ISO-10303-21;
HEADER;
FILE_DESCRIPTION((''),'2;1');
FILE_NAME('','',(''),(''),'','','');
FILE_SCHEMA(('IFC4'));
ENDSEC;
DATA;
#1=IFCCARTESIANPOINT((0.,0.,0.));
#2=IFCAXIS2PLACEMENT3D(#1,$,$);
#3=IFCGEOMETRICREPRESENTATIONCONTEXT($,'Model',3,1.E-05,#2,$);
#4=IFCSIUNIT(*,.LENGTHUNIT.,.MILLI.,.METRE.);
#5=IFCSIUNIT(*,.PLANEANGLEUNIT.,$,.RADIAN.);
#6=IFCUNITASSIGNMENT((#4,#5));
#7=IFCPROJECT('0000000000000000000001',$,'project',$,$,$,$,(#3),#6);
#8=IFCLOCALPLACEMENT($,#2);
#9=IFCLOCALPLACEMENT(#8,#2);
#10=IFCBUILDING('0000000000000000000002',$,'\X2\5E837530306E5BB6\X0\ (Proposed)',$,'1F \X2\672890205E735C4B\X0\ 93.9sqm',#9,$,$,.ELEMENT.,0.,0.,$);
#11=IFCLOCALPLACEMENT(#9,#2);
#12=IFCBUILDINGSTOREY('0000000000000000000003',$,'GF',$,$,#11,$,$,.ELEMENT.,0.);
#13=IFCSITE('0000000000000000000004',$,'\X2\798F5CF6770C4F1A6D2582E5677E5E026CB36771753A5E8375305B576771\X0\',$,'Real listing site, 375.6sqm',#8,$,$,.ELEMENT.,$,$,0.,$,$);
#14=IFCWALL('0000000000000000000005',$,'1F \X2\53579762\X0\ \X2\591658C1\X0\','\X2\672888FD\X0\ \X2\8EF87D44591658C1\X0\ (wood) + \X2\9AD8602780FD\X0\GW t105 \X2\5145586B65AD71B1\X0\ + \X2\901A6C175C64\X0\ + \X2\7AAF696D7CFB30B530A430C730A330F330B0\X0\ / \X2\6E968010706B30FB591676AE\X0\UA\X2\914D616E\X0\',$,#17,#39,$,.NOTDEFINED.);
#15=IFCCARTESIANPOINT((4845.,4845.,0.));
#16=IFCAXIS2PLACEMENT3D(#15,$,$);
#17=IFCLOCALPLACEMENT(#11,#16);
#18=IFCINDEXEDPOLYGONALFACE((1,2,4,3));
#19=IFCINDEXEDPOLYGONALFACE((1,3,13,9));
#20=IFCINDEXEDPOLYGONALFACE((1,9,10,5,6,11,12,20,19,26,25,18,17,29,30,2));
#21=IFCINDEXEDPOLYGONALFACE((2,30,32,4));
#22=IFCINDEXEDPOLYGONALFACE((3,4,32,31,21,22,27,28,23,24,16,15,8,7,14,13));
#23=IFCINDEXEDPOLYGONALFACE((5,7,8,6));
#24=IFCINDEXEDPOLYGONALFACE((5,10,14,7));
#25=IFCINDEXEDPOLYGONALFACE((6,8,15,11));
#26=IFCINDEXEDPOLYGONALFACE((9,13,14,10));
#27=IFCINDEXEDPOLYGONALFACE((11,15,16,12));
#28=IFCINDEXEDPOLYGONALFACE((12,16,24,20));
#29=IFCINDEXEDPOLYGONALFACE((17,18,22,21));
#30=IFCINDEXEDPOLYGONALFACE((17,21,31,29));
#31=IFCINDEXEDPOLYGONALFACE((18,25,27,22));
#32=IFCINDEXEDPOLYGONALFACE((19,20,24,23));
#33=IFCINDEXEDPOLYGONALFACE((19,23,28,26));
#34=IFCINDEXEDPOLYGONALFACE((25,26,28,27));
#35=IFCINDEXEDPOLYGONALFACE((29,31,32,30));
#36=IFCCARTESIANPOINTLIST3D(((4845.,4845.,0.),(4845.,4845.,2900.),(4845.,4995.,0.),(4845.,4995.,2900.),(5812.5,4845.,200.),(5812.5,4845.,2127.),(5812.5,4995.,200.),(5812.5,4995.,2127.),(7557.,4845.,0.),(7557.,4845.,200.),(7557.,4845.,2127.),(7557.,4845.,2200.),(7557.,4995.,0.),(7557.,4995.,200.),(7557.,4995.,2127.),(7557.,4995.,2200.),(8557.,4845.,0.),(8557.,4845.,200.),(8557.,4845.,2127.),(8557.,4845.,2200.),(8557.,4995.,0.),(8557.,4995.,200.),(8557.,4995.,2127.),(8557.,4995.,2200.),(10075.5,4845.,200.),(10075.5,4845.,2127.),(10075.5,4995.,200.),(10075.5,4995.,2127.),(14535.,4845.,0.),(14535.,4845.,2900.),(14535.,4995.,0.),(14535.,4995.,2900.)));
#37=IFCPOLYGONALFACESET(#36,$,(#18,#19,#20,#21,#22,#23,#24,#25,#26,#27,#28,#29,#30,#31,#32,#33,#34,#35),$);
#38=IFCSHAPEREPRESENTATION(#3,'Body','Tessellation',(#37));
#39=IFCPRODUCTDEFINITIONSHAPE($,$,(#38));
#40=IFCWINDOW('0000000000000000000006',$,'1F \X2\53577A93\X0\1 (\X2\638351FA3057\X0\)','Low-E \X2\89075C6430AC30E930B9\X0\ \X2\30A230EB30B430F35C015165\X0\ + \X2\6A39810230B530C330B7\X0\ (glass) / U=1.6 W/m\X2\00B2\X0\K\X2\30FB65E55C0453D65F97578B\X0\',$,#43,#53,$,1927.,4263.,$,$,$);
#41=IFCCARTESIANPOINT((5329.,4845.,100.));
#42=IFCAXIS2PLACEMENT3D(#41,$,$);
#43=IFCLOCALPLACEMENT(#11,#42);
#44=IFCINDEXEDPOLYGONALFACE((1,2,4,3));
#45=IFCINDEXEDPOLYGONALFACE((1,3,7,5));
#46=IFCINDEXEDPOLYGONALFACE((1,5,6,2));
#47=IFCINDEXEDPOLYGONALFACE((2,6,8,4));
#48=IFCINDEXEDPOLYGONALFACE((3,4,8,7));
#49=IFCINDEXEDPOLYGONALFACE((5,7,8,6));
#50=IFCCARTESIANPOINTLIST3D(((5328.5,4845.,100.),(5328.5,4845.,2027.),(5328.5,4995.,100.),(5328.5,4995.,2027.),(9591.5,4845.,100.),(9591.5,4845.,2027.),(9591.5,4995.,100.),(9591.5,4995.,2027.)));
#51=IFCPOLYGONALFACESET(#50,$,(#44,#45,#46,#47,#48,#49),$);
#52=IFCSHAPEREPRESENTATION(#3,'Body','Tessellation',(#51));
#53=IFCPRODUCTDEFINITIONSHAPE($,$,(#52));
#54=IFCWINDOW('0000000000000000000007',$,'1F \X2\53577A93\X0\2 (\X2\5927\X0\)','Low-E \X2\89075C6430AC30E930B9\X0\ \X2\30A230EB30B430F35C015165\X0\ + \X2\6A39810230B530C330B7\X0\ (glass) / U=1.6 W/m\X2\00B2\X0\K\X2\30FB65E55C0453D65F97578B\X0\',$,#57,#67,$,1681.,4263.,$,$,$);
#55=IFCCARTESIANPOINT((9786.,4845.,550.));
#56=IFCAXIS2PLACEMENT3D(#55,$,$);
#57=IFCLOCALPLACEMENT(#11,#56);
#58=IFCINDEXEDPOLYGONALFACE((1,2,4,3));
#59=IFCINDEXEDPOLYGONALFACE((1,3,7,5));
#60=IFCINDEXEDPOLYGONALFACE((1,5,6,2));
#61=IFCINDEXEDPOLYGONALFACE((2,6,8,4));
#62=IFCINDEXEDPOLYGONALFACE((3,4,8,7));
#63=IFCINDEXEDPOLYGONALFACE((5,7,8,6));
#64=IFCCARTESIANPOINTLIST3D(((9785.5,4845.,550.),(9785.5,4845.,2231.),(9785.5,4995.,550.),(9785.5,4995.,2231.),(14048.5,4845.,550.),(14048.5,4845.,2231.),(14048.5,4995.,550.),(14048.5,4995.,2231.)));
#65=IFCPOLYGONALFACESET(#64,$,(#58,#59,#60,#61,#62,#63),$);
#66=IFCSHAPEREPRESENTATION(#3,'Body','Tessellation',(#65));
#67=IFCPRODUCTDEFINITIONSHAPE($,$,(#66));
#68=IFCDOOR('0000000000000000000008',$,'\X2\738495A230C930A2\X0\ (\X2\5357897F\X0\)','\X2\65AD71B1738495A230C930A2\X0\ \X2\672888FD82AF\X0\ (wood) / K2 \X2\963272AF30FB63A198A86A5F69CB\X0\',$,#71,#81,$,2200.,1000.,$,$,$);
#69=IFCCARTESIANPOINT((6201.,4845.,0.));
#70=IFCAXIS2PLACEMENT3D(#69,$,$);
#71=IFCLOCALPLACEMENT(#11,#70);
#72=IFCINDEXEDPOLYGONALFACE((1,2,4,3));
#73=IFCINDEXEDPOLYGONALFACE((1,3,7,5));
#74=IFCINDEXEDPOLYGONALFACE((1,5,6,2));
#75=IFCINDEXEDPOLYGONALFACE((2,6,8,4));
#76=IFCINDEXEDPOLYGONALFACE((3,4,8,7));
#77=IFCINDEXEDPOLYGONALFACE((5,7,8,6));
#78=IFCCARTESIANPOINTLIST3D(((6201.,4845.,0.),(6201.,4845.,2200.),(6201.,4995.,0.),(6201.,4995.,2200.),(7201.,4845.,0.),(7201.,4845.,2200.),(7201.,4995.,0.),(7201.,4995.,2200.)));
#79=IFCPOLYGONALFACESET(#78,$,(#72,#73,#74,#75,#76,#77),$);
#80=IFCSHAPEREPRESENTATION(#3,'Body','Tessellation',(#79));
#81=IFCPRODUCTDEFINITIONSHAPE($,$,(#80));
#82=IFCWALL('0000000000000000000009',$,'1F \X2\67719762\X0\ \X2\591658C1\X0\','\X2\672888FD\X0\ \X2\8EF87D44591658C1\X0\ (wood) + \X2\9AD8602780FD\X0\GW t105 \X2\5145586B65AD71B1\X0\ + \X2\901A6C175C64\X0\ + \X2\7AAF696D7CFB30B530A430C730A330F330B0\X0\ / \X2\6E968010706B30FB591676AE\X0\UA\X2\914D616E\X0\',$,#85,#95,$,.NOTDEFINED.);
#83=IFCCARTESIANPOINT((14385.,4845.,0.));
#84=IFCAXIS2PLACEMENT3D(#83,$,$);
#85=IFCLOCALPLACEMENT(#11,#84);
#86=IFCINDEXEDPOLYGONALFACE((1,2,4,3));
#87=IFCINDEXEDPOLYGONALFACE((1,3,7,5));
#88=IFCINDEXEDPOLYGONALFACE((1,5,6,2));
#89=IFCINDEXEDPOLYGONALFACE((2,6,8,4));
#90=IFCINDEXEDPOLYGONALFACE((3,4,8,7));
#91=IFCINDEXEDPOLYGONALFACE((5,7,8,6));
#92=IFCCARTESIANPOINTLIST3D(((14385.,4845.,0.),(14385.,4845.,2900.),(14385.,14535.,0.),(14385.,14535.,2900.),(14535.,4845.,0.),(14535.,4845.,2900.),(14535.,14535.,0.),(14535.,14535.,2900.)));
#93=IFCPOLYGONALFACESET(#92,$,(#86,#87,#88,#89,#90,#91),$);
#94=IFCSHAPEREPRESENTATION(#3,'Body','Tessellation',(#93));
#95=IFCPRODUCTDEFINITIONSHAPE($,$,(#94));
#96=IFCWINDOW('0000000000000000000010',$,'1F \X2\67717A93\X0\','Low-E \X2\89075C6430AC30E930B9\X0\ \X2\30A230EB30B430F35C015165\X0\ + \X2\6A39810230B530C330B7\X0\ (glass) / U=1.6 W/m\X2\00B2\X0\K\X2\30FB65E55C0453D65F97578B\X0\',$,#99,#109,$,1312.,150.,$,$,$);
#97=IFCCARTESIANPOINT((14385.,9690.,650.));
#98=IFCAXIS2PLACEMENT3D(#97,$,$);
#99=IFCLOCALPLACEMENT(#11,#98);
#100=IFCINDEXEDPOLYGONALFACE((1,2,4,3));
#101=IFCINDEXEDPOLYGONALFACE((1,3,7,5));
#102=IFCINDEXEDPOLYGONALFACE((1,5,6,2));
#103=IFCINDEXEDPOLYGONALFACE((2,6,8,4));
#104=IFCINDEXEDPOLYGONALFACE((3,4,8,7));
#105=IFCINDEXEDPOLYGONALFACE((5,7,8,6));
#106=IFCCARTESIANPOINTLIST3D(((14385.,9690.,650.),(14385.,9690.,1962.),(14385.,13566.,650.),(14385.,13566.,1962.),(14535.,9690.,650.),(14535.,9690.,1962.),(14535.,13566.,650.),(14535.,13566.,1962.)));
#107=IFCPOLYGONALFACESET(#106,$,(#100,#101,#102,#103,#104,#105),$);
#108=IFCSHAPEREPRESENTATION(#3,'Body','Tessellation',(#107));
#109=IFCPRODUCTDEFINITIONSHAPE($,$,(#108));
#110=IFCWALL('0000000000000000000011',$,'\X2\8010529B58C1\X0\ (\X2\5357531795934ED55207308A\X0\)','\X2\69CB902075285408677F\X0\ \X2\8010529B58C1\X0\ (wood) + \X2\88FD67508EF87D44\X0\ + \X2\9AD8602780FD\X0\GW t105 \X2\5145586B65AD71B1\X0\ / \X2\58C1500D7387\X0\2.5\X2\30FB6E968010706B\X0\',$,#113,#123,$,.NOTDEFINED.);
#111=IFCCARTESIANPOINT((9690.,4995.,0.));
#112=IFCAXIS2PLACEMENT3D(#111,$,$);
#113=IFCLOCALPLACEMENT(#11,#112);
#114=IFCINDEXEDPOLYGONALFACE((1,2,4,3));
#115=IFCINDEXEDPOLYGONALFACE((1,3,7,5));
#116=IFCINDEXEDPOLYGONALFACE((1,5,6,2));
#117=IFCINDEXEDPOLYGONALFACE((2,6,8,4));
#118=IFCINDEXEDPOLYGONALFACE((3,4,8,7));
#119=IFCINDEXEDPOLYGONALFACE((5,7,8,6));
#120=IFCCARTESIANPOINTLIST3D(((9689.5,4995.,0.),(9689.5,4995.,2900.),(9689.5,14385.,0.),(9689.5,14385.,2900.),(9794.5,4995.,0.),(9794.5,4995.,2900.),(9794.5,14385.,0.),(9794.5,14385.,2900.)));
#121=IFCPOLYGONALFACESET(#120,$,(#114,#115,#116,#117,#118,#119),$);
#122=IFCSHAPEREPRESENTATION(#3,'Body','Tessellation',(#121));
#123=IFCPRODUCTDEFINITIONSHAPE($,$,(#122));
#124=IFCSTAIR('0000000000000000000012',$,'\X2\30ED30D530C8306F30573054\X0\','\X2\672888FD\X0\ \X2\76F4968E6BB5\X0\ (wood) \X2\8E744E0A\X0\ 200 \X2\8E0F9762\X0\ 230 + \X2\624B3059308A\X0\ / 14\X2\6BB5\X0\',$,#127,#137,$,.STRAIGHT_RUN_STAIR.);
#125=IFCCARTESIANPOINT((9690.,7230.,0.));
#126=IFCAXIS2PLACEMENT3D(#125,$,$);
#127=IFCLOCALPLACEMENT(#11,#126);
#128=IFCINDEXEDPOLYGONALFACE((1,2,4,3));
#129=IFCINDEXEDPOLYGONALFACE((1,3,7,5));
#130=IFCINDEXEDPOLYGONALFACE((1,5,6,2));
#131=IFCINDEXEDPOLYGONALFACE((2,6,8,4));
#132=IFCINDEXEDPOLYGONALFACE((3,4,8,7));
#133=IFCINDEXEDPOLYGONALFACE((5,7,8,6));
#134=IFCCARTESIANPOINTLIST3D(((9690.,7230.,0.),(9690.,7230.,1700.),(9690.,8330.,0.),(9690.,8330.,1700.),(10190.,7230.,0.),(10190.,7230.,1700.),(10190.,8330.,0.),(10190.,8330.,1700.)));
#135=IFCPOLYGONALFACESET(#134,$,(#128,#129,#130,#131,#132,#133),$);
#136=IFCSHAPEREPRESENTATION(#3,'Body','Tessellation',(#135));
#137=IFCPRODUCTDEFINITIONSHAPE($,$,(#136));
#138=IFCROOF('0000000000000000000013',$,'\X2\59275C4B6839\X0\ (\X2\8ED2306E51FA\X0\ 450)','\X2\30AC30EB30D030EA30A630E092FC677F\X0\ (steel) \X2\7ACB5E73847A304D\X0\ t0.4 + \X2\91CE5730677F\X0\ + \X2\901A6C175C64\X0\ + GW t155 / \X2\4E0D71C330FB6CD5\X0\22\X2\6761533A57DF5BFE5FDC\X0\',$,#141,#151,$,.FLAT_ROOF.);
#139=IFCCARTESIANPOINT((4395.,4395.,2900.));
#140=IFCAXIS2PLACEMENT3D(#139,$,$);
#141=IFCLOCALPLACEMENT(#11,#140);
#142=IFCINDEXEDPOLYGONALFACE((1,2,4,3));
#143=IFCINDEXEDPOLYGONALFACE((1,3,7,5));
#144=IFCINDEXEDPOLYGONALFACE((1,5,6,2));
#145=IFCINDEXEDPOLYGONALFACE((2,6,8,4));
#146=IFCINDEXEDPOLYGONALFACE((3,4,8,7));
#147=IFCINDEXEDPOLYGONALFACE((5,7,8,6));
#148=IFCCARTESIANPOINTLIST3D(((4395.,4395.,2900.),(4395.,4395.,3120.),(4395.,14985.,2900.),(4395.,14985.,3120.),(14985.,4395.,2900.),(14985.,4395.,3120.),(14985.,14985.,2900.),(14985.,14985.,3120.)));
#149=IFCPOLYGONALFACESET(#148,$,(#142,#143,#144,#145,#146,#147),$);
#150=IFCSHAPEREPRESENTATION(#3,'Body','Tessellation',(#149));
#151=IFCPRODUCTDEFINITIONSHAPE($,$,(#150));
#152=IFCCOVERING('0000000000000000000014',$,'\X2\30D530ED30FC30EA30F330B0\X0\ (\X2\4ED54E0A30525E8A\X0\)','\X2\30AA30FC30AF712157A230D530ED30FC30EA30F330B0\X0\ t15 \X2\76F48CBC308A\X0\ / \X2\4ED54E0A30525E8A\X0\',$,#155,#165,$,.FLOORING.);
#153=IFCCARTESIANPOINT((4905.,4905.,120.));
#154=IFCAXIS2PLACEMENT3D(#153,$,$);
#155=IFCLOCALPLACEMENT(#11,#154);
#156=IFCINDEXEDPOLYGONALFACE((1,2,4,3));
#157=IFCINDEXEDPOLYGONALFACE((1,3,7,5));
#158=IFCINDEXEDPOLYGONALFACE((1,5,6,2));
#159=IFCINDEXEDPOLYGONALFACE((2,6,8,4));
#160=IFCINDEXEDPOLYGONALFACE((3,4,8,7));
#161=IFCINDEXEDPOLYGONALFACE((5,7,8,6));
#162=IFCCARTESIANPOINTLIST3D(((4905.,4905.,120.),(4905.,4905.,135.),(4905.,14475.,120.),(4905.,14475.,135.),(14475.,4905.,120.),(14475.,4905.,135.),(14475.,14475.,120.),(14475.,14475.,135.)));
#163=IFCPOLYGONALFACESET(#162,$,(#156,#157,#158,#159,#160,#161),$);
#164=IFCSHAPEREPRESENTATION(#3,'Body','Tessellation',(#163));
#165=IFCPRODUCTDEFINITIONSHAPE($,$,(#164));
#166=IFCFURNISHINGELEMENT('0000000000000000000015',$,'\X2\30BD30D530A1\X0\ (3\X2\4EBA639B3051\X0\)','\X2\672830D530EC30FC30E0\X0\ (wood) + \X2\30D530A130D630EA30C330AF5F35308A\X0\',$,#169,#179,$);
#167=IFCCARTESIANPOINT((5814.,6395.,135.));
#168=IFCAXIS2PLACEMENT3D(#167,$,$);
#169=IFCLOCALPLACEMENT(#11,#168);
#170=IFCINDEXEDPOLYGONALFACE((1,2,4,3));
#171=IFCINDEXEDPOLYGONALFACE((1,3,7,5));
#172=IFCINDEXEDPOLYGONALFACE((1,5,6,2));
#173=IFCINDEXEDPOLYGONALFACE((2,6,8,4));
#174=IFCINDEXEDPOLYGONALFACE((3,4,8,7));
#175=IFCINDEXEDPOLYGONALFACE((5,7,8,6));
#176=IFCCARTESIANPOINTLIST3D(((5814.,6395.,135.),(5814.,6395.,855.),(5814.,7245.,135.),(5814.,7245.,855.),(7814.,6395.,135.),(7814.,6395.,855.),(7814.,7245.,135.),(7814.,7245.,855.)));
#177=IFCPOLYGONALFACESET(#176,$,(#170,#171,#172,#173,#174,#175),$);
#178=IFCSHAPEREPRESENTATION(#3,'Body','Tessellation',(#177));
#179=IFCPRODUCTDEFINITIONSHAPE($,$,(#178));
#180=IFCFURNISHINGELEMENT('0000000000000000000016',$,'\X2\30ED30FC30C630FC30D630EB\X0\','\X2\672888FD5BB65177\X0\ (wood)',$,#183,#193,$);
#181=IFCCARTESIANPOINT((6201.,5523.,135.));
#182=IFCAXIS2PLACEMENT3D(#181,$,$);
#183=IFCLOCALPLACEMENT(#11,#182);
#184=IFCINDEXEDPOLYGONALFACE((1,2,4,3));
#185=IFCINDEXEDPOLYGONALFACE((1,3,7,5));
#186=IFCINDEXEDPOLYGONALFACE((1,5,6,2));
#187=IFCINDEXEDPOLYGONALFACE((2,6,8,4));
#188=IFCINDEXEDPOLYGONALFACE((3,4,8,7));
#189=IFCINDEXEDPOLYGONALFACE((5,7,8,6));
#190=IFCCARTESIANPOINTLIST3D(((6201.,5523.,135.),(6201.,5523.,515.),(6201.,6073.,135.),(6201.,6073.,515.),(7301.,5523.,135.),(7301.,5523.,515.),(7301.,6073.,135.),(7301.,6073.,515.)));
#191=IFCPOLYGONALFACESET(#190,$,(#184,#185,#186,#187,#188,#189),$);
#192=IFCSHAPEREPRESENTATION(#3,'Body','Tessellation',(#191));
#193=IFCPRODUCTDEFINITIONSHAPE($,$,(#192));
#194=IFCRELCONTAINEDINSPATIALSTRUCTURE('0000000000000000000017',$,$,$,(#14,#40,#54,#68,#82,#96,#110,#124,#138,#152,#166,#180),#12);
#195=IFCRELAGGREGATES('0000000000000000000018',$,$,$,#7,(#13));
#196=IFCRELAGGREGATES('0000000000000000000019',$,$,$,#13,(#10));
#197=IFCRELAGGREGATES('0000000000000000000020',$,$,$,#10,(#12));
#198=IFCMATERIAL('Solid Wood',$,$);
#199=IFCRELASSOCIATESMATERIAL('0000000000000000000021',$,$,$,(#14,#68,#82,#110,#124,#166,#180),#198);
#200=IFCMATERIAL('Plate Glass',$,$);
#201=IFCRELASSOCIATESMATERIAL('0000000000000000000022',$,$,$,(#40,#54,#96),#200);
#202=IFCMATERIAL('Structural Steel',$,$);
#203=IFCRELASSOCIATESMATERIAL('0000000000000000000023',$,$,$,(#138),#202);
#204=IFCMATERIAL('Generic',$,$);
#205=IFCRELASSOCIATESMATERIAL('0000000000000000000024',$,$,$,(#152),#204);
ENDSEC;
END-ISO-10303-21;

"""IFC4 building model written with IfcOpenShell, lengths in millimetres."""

from ifc_helpers import new_model, si_unit, frame, frame_2d, origin, place, context, project, spatial, rectangle, extrude, material, element, fill, save


model = new_model("IFC4")

# Units and contexts
model_context = context("Model", 3, precision=1e-05, world=origin())
ifc_project = project(units=[si_unit("LENGTHUNIT", "METRE", prefix="MILLI"), si_unit("PLANEANGLEUNIT", "RADIAN")], contexts=[model_context])

# Site, building, storey
site_placement = place(None, origin())
site = spatial("IfcSite", under=ifc_project, at=site_placement, Name="福島県会津若松市河東町広田字東", ObjectType="Real listing site, 375.6sqm", CompositionType="ELEMENT", RefElevation=0.0)
building_placement = place(site_placement, origin())
building = spatial("IfcBuilding", under=site, at=building_placement, Name="広田の家 (Proposed)", ObjectType="1F 木造平屋 93.9sqm", CompositionType="ELEMENT", ElevationOfRefHeight=0.0, ElevationOfTerrain=0.0)
storey_placement = place(building_placement, origin())
storey = spatial("IfcBuildingStorey", under=building, at=storey_placement, Name="GF", CompositionType="ELEMENT", Elevation=0.0)

# Shared definitions
ifc_material_1 = material(Name="Solid Wood")

# Wall, openings, windows, door
wall_1_placement = place(storey_placement, frame((4845.0, 4845.0, 0.0)))
wall_1 = element("IfcWall", 1, at=wall_1_placement, inside=storey, material=ifc_material_1, Name="1F 南面 外壁", Description="木製 軸組外壁 (wood) + 高性能GW t105 充填断熱 + 通気層 + 窯業系サイディング / 準耐火・外皮UA配慮", PredefinedType="NOTDEFINED", context=model_context, shape_type="SweptSolid", body=[
    extrude(rectangle(XDim=9690.0, YDim=150.0, at=frame_2d((4845.0, 75.0))), frame((4845.0, 4845.0, 0.0)), (0.0, 0.0, 1.0), 2900.0),
])
opening_1_placement = place(storey_placement, frame((5329.0, 4845.0, 100.0)))
opening_1 = element("IfcOpeningElement", 2, at=opening_1_placement, cuts=wall_1, PredefinedType="NOTDEFINED", context=model_context, shape_type="SweptSolid", body=[
    extrude(rectangle(XDim=4263.0, YDim=150.0, at=frame_2d((2131.0, 75.0))), frame((5329.0, 4845.0, 100.0)), (0.0, 0.0, 1.0), 1927.0),
])
opening_2_placement = place(storey_placement, frame((9786.0, 4845.0, 550.0)))
opening_2 = element("IfcOpeningElement", 3, at=opening_2_placement, cuts=wall_1, PredefinedType="NOTDEFINED", context=model_context, shape_type="SweptSolid", body=[
    extrude(rectangle(XDim=4263.0, YDim=150.0, at=frame_2d((2131.0, 75.0))), frame((9786.0, 4845.0, 550.0)), (0.0, 0.0, 1.0), 1681.0),
])
opening_3_placement = place(storey_placement, frame((6201.0, 4845.0, 0.0)))
opening_3 = element("IfcOpeningElement", 4, at=opening_3_placement, cuts=wall_1, PredefinedType="NOTDEFINED", context=model_context, shape_type="SweptSolid", body=[
    extrude(rectangle(XDim=1000.0, YDim=150.0, at=frame_2d((500.0, 75.0))), frame((6201.0, 4845.0, 0.0)), (0.0, 0.0, 1.0), 2200.0),
])
ifc_material_2 = material(Name="Plate Glass")
window_1_placement = place(storey_placement, frame((5329.0, 4845.0, 100.0)))
window_1 = element("IfcWindow", 5, at=window_1_placement, inside=storey, material=ifc_material_2, Name="1F 南窓1 (掃出し)", Description="Low-E 複層ガラス アルゴン封入 + 樹脂サッシ (glass) / U=1.6 W/m²K・日射取得型", OverallHeight=1927.0, OverallWidth=4263.0, context=model_context, shape_type="SweptSolid", body=[
    extrude(rectangle(XDim=4263.0, YDim=150.0, at=frame_2d((2131.0, 75.0))), frame((5329.0, 4845.0, 100.0)), (0.0, 0.0, 1.0), 1927.0),
])
fill(opening_1, window_1)
window_2_placement = place(storey_placement, frame((9786.0, 4845.0, 550.0)))
window_2 = element("IfcWindow", 6, at=window_2_placement, inside=storey, material=ifc_material_2, Name="1F 南窓2 (大)", Description="Low-E 複層ガラス アルゴン封入 + 樹脂サッシ (glass) / U=1.6 W/m²K・日射取得型", OverallHeight=1681.0, OverallWidth=4263.0, context=model_context, shape_type="SweptSolid", body=[
    extrude(rectangle(XDim=4263.0, YDim=150.0, at=frame_2d((2131.0, 75.0))), frame((9786.0, 4845.0, 550.0)), (0.0, 0.0, 1.0), 1681.0),
])
fill(opening_2, window_2)
door_placement = place(storey_placement, frame((6201.0, 4845.0, 0.0)))
door = element("IfcDoor", 7, at=door_placement, inside=storey, material=ifc_material_1, Name="玄関ドア (南西)", Description="断熱玄関ドア 木製芯 (wood) / K2 防犯・採風機構", OverallHeight=2200.0, OverallWidth=1000.0, context=model_context, shape_type="SweptSolid", body=[
    extrude(rectangle(XDim=1000.0, YDim=150.0, at=frame_2d((500.0, 75.0))), frame((6201.0, 4845.0, 0.0)), (0.0, 0.0, 1.0), 2200.0),
])
fill(opening_3, door)

# Wall, opening, window
wall_2_placement = place(storey_placement, frame((14385.0, 4845.0, 0.0)))
wall_2 = element("IfcWall", 8, at=wall_2_placement, inside=storey, material=ifc_material_1, Name="1F 東面 外壁", Description="木製 軸組外壁 (wood) + 高性能GW t105 充填断熱 + 通気層 + 窯業系サイディング / 準耐火・外皮UA配慮", PredefinedType="NOTDEFINED", context=model_context, shape_type="SweptSolid", body=[
    extrude(rectangle(XDim=150.0, YDim=9690.0, at=frame_2d((75.0, 4845.0))), frame((14385.0, 4845.0, 0.0)), (0.0, 0.0, 1.0), 2900.0),
])
opening_4_placement = place(storey_placement, frame((14385.0, 9690.0, 650.0)))
opening_4 = element("IfcOpeningElement", 9, at=opening_4_placement, cuts=wall_2, PredefinedType="NOTDEFINED", context=model_context, shape_type="SweptSolid", body=[
    extrude(rectangle(XDim=150.0, YDim=3876.0, at=frame_2d((75.0, 1938.0))), frame((14385.0, 9690.0, 650.0)), (0.0, 0.0, 1.0), 1312.0),
])
window_3_placement = place(storey_placement, frame((14385.0, 9690.0, 650.0)))
window_3 = element("IfcWindow", 10, at=window_3_placement, inside=storey, material=ifc_material_2, Name="1F 東窓", Description="Low-E 複層ガラス アルゴン封入 + 樹脂サッシ (glass) / U=1.6 W/m²K・日射取得型", OverallHeight=1312.0, OverallWidth=150.0, context=model_context, shape_type="SweptSolid", body=[
    extrude(rectangle(XDim=150.0, YDim=3876.0, at=frame_2d((75.0, 1938.0))), frame((14385.0, 9690.0, 650.0)), (0.0, 0.0, 1.0), 1312.0),
])
fill(opening_4, window_3)

# Wall
wall_3_placement = place(storey_placement, frame((9690.0, 4995.0, 0.0)))
element("IfcWall", 11, at=wall_3_placement, inside=storey, material=ifc_material_1, Name="耐力壁 (南北間仕切り)", Description="構造用合板 耐力壁 (wood) + 製材軸組 + 高性能GW t105 充填断熱 / 壁倍率2.5・準耐火", PredefinedType="NOTDEFINED", context=model_context, shape_type="SweptSolid", body=[
    extrude(rectangle(XDim=105.0, YDim=9390.0, at=frame_2d((52.0, 4695.0))), frame((9690.0, 4995.0, 0.0)), (0.0, 0.0, 1.0), 2900.0),
])

# Stair
stair_placement = place(storey_placement, frame((9690.0, 7230.0, 0.0)))
element("IfcStair", 12, at=stair_placement, inside=storey, material=ifc_material_1, Name="ロフトはしご", Description="木製 直階段 (wood) 蹴上 200 踏面 230 + 手すり / 14段", PredefinedType="STRAIGHT_RUN_STAIR", context=model_context, shape_type="SweptSolid", body=[
    extrude(rectangle(XDim=500.0, YDim=1100.0, at=frame_2d((250.0, 550.0))), frame((9690.0, 7230.0, 0.0)), (0.0, 0.0, 1.0), 1700.0),
])

# Roof
ifc_material_3 = material(Name="Structural Steel")
roof_placement = place(storey_placement, frame((4395.0, 4395.0, 2900.0)))
element("IfcRoof", 13, at=roof_placement, inside=storey, material=ifc_material_3, Name="大屋根 (軒の出 450)", Description="ガルバリウム鋼板 (steel) 立平葺き t0.4 + 野地板 + 通気層 + GW t155 / 不燃・法22条区域対応", PredefinedType="FLAT_ROOF", context=model_context, shape_type="SweptSolid", body=[
    extrude(rectangle(XDim=10590.0, YDim=10590.0, at=frame_2d((5295.0, 5295.0))), frame((4395.0, 4395.0, 2900.0)), (0.0, 0.0, 1.0), 220.0),
])

# Covering
ifc_material_4 = material(Name="Generic")
covering_placement = place(storey_placement, frame((4905.0, 4905.0, 120.0)))
element("IfcCovering", 14, at=covering_placement, inside=storey, material=ifc_material_4, Name="フローリング (仕上げ床)", Description="オーク無垢フローリング t15 直貼り / 仕上げ床", PredefinedType="FLOORING", context=model_context, shape_type="SweptSolid", body=[
    extrude(rectangle(XDim=9570.0, YDim=9570.0, at=frame_2d((4785.0, 4785.0))), frame((4905.0, 4905.0, 120.0)), (0.0, 0.0, 1.0), 15.0),
])

# Furnishing elements
furnishing_1_placement = place(storey_placement, frame((5814.0, 6395.0, 135.0)))
element("IfcFurnishingElement", 15, at=furnishing_1_placement, inside=storey, material=ifc_material_1, Name="ソファ (3人掛け)", Description="木フレーム (wood) + ファブリック張り", context=model_context, shape_type="SweptSolid", body=[
    extrude(rectangle(XDim=2000.0, YDim=850.0, at=frame_2d((1000.0, 425.0))), frame((5814.0, 6395.0, 135.0)), (0.0, 0.0, 1.0), 720.0),
])
furnishing_2_placement = place(storey_placement, frame((6201.0, 5523.0, 135.0)))
element("IfcFurnishingElement", 16, at=furnishing_2_placement, inside=storey, material=ifc_material_1, Name="ローテーブル", Description="木製家具 (wood)", context=model_context, shape_type="SweptSolid", body=[
    extrude(rectangle(XDim=1100.0, YDim=550.0, at=frame_2d((550.0, 275.0))), frame((6201.0, 5523.0, 135.0)), (0.0, 0.0, 1.0), 380.0),
])

save(model, "model.ifc")
